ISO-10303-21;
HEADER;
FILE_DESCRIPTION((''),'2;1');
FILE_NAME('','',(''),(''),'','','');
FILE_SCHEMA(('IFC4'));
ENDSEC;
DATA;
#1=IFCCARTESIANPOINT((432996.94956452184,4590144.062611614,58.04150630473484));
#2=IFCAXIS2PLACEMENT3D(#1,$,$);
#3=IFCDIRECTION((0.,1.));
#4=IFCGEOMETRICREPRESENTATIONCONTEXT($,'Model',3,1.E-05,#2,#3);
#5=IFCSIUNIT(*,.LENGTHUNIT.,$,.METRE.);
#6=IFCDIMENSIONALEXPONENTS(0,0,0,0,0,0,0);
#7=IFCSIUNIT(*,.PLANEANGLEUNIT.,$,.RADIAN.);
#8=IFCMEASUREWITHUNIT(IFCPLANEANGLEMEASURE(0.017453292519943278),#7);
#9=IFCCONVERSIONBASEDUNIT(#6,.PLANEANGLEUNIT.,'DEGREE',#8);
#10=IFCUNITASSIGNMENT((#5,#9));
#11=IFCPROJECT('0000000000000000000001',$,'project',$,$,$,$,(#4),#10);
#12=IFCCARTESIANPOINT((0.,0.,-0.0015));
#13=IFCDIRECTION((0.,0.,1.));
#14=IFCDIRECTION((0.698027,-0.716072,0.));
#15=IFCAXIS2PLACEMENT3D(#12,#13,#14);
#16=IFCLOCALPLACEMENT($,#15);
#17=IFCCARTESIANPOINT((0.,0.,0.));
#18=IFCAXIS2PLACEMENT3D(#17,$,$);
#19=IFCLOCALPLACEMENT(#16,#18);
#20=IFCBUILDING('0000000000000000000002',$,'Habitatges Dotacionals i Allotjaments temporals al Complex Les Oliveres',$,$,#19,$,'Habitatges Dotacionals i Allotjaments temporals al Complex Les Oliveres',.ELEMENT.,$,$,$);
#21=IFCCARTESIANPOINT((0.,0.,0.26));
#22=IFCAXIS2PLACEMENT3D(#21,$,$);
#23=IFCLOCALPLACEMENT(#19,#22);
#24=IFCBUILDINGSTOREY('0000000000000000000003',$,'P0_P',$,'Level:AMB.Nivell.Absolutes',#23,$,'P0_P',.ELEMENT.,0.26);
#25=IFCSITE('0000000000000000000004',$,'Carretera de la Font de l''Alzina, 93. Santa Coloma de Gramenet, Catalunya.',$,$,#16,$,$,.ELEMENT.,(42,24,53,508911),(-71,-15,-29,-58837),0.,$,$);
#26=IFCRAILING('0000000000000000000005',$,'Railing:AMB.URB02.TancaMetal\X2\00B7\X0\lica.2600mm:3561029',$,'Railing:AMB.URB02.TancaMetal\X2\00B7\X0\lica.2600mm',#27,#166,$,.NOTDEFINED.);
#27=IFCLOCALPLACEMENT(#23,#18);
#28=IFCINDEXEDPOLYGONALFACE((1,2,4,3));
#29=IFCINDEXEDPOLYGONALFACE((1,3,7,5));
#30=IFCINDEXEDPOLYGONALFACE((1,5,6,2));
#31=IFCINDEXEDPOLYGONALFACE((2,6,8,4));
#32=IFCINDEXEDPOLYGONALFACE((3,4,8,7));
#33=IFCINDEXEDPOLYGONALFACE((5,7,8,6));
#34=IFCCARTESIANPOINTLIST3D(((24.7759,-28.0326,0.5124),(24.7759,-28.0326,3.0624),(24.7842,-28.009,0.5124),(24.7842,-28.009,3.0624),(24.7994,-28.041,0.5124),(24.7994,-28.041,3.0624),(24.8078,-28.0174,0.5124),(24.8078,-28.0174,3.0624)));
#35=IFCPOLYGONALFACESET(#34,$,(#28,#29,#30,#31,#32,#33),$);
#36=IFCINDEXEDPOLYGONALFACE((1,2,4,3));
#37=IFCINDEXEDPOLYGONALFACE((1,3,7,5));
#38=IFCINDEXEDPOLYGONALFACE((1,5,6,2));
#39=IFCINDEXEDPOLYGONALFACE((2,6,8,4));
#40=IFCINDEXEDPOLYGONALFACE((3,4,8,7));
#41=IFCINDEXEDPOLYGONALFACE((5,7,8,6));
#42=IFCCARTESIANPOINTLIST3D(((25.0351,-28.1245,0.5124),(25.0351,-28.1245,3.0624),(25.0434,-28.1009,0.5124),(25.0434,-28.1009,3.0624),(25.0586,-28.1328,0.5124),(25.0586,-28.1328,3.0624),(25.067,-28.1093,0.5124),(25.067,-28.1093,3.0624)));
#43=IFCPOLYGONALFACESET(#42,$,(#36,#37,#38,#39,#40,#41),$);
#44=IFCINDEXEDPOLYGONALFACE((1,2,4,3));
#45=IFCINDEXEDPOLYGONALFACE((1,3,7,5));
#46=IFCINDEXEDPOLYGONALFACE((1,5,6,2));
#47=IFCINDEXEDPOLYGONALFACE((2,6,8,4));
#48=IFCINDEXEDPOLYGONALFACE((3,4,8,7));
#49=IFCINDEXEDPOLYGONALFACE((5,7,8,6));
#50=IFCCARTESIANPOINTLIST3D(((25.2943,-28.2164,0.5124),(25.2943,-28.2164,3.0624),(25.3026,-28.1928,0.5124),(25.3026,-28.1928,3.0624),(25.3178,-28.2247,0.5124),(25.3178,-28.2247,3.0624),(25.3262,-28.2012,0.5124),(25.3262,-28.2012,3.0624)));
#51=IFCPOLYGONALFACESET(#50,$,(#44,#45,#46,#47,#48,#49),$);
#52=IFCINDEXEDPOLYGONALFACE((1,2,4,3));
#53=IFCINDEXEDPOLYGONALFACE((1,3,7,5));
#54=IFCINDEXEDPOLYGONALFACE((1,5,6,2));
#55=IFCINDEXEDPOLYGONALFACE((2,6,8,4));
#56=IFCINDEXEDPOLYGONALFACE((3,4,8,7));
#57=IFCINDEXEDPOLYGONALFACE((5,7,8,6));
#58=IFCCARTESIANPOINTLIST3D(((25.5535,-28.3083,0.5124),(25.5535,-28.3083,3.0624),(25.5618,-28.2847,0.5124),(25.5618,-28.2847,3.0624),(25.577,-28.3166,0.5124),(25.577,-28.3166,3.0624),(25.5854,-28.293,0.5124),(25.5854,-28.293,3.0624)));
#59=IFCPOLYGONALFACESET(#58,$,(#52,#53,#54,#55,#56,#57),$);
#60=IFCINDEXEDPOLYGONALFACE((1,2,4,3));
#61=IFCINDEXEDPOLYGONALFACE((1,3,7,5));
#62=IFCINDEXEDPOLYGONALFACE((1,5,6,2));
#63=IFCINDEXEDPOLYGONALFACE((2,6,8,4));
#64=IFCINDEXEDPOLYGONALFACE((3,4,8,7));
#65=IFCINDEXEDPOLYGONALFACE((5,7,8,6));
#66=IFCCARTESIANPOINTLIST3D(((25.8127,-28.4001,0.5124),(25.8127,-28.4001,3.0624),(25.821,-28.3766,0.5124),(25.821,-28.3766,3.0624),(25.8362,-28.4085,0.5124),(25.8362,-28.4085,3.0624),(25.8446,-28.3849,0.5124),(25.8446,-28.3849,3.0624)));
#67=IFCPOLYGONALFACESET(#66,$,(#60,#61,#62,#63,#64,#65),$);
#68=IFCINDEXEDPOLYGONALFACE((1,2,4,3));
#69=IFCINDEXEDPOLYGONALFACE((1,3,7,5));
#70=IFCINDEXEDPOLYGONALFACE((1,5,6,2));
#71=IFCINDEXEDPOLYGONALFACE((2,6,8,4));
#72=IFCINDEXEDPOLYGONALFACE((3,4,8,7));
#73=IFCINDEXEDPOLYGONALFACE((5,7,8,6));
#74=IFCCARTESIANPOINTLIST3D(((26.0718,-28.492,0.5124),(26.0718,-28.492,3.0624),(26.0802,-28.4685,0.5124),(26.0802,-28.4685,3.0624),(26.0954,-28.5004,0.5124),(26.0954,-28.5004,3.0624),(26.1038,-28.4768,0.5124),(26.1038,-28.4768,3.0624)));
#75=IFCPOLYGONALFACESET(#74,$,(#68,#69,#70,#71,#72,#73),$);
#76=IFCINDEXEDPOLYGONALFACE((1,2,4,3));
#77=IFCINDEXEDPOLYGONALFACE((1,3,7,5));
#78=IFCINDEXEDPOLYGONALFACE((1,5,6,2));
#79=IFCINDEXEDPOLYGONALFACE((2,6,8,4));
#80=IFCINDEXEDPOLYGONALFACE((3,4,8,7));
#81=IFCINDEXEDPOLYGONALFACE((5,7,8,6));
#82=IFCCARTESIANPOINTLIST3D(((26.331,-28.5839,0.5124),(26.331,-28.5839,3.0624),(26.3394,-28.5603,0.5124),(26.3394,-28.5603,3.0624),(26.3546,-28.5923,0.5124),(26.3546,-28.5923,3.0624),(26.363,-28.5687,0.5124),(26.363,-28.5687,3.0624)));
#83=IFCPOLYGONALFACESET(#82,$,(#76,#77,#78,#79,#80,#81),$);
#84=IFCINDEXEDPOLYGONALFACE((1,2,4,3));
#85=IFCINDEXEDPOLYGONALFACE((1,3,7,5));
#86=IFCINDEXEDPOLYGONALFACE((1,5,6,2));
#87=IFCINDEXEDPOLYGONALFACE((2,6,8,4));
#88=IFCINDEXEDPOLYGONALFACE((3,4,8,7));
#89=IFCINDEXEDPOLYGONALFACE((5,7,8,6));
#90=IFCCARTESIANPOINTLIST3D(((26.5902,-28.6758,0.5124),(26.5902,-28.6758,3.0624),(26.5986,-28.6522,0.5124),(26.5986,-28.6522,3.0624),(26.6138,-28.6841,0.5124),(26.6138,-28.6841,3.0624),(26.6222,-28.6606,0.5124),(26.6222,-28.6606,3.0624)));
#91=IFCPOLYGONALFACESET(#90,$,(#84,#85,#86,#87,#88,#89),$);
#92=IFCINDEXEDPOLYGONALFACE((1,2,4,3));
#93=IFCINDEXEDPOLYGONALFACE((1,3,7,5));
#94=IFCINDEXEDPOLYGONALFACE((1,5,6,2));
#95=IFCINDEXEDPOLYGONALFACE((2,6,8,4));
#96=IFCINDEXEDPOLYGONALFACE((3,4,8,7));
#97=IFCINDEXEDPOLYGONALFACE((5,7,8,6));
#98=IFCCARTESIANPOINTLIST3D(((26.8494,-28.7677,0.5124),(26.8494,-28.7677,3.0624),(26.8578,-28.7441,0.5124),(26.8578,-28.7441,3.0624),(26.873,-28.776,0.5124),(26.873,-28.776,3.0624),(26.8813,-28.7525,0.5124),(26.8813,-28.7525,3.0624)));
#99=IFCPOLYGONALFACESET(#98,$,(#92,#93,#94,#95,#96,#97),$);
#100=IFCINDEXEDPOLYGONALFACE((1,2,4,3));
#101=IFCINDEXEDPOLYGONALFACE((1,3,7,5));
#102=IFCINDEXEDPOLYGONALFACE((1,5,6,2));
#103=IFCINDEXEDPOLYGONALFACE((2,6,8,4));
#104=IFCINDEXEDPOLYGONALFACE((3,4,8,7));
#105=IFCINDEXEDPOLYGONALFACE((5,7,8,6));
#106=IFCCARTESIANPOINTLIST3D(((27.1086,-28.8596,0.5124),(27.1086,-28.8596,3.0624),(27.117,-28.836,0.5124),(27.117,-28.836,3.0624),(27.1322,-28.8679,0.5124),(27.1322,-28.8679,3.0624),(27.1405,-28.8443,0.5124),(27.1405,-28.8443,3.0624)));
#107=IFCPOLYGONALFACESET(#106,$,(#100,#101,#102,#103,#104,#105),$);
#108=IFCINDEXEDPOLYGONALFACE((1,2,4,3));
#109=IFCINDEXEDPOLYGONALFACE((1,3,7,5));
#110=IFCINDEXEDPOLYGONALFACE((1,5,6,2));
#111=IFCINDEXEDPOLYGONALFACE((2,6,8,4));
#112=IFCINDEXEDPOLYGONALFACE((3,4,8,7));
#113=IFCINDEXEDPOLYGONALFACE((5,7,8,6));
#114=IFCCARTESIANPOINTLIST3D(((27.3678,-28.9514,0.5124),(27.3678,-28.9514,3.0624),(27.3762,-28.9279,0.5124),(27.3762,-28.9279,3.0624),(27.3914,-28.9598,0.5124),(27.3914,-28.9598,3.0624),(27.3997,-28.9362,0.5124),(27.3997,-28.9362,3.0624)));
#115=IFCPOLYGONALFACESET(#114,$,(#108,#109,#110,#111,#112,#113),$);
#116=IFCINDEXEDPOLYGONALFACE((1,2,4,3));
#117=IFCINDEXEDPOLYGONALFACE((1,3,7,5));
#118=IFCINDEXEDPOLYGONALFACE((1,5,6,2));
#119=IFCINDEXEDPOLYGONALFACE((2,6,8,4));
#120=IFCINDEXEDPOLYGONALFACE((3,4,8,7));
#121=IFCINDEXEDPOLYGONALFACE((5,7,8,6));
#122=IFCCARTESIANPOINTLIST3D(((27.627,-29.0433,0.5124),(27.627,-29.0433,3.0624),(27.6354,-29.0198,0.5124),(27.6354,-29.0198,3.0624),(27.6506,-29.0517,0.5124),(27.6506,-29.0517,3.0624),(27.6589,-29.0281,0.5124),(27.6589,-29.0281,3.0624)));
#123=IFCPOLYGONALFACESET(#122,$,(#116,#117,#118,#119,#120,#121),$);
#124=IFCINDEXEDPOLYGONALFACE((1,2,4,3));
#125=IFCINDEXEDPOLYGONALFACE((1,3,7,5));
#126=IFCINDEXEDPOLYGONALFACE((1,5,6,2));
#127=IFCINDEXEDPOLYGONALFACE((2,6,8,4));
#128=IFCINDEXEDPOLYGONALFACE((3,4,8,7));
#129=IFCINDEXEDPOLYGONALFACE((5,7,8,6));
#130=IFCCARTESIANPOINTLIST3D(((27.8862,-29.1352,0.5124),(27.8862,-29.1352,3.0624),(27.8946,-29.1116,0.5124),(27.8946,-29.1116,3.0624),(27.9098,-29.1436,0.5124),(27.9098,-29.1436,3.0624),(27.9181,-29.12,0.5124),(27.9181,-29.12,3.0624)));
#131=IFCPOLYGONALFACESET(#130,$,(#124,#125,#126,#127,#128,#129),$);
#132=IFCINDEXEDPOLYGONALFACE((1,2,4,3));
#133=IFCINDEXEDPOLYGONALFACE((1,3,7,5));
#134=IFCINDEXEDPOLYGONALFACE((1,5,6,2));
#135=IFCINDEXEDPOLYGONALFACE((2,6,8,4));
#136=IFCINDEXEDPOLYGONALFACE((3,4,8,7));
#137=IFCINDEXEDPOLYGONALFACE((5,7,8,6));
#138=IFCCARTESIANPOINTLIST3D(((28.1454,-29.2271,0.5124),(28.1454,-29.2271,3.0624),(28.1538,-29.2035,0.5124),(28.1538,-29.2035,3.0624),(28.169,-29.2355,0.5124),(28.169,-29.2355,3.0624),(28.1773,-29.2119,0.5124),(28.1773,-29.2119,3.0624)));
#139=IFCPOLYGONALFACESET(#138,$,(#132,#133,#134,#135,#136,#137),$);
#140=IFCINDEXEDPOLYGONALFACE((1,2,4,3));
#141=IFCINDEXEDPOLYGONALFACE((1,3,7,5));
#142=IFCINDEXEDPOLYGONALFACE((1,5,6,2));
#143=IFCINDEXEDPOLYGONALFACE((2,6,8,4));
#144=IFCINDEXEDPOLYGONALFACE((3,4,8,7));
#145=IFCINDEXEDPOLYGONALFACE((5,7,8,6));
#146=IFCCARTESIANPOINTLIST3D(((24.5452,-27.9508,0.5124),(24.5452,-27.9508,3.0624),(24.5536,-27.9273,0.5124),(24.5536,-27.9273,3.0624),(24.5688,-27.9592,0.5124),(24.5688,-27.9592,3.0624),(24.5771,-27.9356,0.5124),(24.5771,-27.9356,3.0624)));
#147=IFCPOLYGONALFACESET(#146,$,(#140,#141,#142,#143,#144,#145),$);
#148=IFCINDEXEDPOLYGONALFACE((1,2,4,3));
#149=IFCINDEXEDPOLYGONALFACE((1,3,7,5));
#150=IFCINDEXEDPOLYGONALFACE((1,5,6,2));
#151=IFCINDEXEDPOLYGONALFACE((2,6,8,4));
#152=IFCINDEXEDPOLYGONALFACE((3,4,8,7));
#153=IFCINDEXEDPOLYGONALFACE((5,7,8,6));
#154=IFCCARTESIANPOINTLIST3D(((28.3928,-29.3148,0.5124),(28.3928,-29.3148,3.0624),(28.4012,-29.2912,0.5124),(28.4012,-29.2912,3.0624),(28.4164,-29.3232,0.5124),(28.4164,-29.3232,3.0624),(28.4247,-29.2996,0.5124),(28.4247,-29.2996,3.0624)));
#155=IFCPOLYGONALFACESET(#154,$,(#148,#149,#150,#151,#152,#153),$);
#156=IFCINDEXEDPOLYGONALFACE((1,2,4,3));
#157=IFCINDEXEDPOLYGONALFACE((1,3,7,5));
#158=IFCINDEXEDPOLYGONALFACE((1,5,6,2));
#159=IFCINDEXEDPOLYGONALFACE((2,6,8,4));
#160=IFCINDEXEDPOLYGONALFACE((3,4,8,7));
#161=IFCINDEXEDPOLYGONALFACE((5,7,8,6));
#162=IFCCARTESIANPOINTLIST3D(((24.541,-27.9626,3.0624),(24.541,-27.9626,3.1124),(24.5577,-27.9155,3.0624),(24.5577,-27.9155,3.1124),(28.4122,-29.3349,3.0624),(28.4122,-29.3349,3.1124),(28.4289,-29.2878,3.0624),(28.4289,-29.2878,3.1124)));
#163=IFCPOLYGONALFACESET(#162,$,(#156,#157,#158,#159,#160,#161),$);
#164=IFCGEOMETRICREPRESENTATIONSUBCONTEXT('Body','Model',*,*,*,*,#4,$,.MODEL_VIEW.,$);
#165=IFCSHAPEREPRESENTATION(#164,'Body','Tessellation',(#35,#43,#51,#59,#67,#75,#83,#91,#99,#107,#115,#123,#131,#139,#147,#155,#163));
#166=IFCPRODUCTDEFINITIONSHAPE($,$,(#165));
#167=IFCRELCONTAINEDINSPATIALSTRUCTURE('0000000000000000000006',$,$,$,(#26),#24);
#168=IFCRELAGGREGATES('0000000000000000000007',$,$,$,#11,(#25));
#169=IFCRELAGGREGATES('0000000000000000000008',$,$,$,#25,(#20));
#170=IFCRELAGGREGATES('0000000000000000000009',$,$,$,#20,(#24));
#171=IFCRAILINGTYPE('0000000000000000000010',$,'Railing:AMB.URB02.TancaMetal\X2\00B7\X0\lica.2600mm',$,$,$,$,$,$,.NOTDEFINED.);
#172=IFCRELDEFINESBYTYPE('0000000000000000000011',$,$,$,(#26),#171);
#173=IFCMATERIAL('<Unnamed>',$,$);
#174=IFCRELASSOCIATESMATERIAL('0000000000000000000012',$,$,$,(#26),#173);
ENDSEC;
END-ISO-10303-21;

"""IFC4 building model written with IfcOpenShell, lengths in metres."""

from ifc_helpers import new_model, entity, si_unit, converted_unit, direction, frame, origin, place, context, subcontext, project, spatial, indexed_curve, outline, extrude, material, type_object, element, save


model = new_model("IFC4")

# Units and contexts
model_context = context("Model", 3, precision=1e-05, world=frame((432996.94956452184, 4590144.062611614, 58.04150630473484)), true_north=direction((0.0, 1.0)))
body_context = subcontext(model_context, "Body", "Model", "MODEL_VIEW")
ifc_project = project(units=[si_unit("LENGTHUNIT", "METRE"), converted_unit("PLANEANGLEUNIT", "DEGREE", entity("IfcPlaneAngleMeasure", 0.017453292519943278), si_unit("PLANEANGLEUNIT", "RADIAN"), dimensions=[0, 0, 0, 0, 0, 0, 0])], contexts=[model_context])

# Site, building, storey
site_placement = place(None, frame((0.0, 0.0, -0.0015), z_axis=(0.0, 0.0, 1.0), x_axis=(0.698027, -0.716072, 0.0)))
site = spatial("IfcSite", under=ifc_project, at=site_placement, Name="Carretera de la Font de l'Alzina, 93. Santa Coloma de Gramenet, Catalunya.", CompositionType="ELEMENT", RefLatitude=(42, 24, 53, 508911), RefLongitude=(-71, -15, -29, -58837), RefElevation=0.0)
building_placement = place(site_placement, origin())
building = spatial("IfcBuilding", under=site, at=building_placement, Name="Habitatges Dotacionals i Allotjaments temporals al Complex Les Oliveres", LongName="Habitatges Dotacionals i Allotjaments temporals al Complex Les Oliveres", CompositionType="ELEMENT")
storey_placement = place(building_placement, frame((0.0, 0.0, 0.26)))
storey = spatial("IfcBuildingStorey", under=building, at=storey_placement, Name="P0_P", ObjectType="Level:AMB.Nivell.Absolutes", LongName="P0_P", CompositionType="ELEMENT", Elevation=0.26)

# Shared definitions
ifc_material_1 = material(Name="<Unnamed>")

# Railing
railing_type = type_object("IfcRailingType", Name="Railing:AMB.URB02.TancaMetal·lica.2600mm", PredefinedType="NOTDEFINED")
railing_placement = place(storey_placement, origin())
element("IfcRailing", 1, at=railing_placement, inside=storey, type_object=railing_type, material=ifc_material_1, Name="Railing:AMB.URB02.TancaMetal·lica.2600mm:3561029", ObjectType="Railing:AMB.URB02.TancaMetal·lica.2600mm", PredefinedType="NOTDEFINED", context=body_context, shape_type="SweptSolid", body=[
    extrude(outline(indexed_curve([(-0.0125, -0.0125), (0.0125, -0.0125), (0.0125, 0.0125), (-0.0125, 0.0125), (-0.0125, -0.0125)], self_intersect=False)), frame((24.7918, -28.025, 0.5124), z_axis=(0.0, 0.0, 1.0), x_axis=(-0.942529, 0.334126, 0.0)), (0.0, 0.0, 1.0), 2.55),
    extrude(outline(indexed_curve([(-0.0125, -0.0125), (0.0125, -0.0125), (0.0125, 0.0125), (-0.0125, 0.0125), (-0.0125, -0.0125)], self_intersect=False)), frame((25.051, -28.1169, 0.5124), z_axis=(0.0, 0.0, 1.0), x_axis=(-0.942529, 0.334126, 0.0)), (0.0, 0.0, 1.0), 2.55),
    extrude(outline(indexed_curve([(-0.0125, -0.0125), (0.0125, -0.0125), (0.0125, 0.0125), (-0.0125, 0.0125), (-0.0125, -0.0125)], self_intersect=False)), frame((25.3102, -28.2088, 0.5124), z_axis=(0.0, 0.0, 1.0), x_axis=(-0.942529, 0.334126, 0.0)), (0.0, 0.0, 1.0), 2.55),
    extrude(outline(indexed_curve([(-0.0125, -0.0125), (0.0125, -0.0125), (0.0125, 0.0125), (-0.0125, 0.0125), (-0.0125, -0.0125)], self_intersect=False)), frame((25.5694, -28.3006, 0.5124), z_axis=(0.0, 0.0, 1.0), x_axis=(-0.942529, 0.334126, 0.0)), (0.0, 0.0, 1.0), 2.55),
    extrude(outline(indexed_curve([(-0.0125, -0.0125), (0.0125, -0.0125), (0.0125, 0.0125), (-0.0125, 0.0125), (-0.0125, -0.0125)], self_intersect=False)), frame((25.8286, -28.3925, 0.5124), z_axis=(0.0, 0.0, 1.0), x_axis=(-0.942529, 0.334126, 0.0)), (0.0, 0.0, 1.0), 2.55),
    extrude(outline(indexed_curve([(-0.0125, -0.0125), (0.0125, -0.0125), (0.0125, 0.0125), (-0.0125, 0.0125), (-0.0125, -0.0125)], self_intersect=False)), frame((26.0878, -28.4844, 0.5124), z_axis=(0.0, 0.0, 1.0), x_axis=(-0.942529, 0.334126, 0.0)), (0.0, 0.0, 1.0), 2.55),
    extrude(outline(indexed_curve([(-0.0125, -0.0125), (0.0125, -0.0125), (0.0125, 0.0125), (-0.0125, 0.0125), (-0.0125, -0.0125)], self_intersect=False)), frame((26.347, -28.5763, 0.5124), z_axis=(0.0, 0.0, 1.0), x_axis=(-0.942529, 0.334126, 0.0)), (0.0, 0.0, 1.0), 2.55),
    extrude(outline(indexed_curve([(-0.0125, -0.0125), (0.0125, -0.0125), (0.0125, 0.0125), (-0.0125, 0.0125), (-0.0125, -0.0125)], self_intersect=False)), frame((26.6062, -28.6682, 0.5124), z_axis=(0.0, 0.0, 1.0), x_axis=(-0.942529, 0.334126, 0.0)), (0.0, 0.0, 1.0), 2.55),
    extrude(outline(indexed_curve([(-0.0125, -0.0125), (0.0125, -0.0125), (0.0125, 0.0125), (-0.0125, 0.0125), (-0.0125, -0.0125)], self_intersect=False)), frame((26.8654, -28.7601, 0.5124), z_axis=(0.0, 0.0, 1.0), x_axis=(-0.942529, 0.334126, 0.0)), (0.0, 0.0, 1.0), 2.55),
    extrude(outline(indexed_curve([(-0.0125, -0.0125), (0.0125, -0.0125), (0.0125, 0.0125), (-0.0125, 0.0125), (-0.0125, -0.0125)], self_intersect=False)), frame((27.1246, -28.852, 0.5124), z_axis=(0.0, 0.0, 1.0), x_axis=(-0.942529, 0.334126, 0.0)), (0.0, 0.0, 1.0), 2.55),
    extrude(outline(indexed_curve([(-0.0125, -0.0125), (0.0125, -0.0125), (0.0125, 0.0125), (-0.0125, 0.0125), (-0.0125, -0.0125)], self_intersect=False)), frame((27.3838, -28.9438, 0.5124), z_axis=(0.0, 0.0, 1.0), x_axis=(-0.942529, 0.334126, 0.0)), (0.0, 0.0, 1.0), 2.55),
    extrude(outline(indexed_curve([(-0.0125, -0.0125), (0.0125, -0.0125), (0.0125, 0.0125), (-0.0125, 0.0125), (-0.0125, -0.0125)], self_intersect=False)), frame((27.643, -29.0357, 0.5124), z_axis=(0.0, 0.0, 1.0), x_axis=(-0.942529, 0.334126, 0.0)), (0.0, 0.0, 1.0), 2.55),
    extrude(outline(indexed_curve([(-0.0125, -0.0125), (0.0125, -0.0125), (0.0125, 0.0125), (-0.0125, 0.0125), (-0.0125, -0.0125)], self_intersect=False)), frame((27.9022, -29.1276, 0.5124), z_axis=(0.0, 0.0, 1.0), x_axis=(-0.942529, 0.334126, 0.0)), (0.0, 0.0, 1.0), 2.55),
    extrude(outline(indexed_curve([(-0.0125, -0.0125), (0.0125, -0.0125), (0.0125, 0.0125), (-0.0125, 0.0125), (-0.0125, -0.0125)], self_intersect=False)), frame((28.1614, -29.2195, 0.5124), z_axis=(0.0, 0.0, 1.0), x_axis=(-0.942529, 0.334126, 0.0)), (0.0, 0.0, 1.0), 2.55),
    extrude(outline(indexed_curve([(-0.0125, -0.0125), (0.0125, -0.0125), (0.0125, 0.0125), (-0.0125, 0.0125), (-0.0125, -0.0125)], self_intersect=False)), frame((24.5612, -27.9432, 0.5124), z_axis=(0.0, 0.0, 1.0), x_axis=(-0.942529, 0.334126, 0.0)), (0.0, 0.0, 1.0), 2.55),
    extrude(outline(indexed_curve([(-0.0125, -0.0125), (0.0125, -0.0125), (0.0125, 0.0125), (-0.0125, 0.0125), (-0.0125, -0.0125)], self_intersect=False)), frame((28.4088, -29.3072, 0.5124), z_axis=(0.0, 0.0, 1.0), x_axis=(-0.942529, 0.334126, 0.0)), (0.0, 0.0, 1.0), 2.55),
    extrude(outline(indexed_curve([(-2.0536, -0.025), (2.0536, -0.025), (2.0536, 0.025), (-2.0536, 0.025), (-2.0536, -0.025)], self_intersect=False)), frame((26.485, -28.6252, 3.0624), z_axis=(0.0, 0.0, 1.0), x_axis=(-0.942529, 0.334126, 0.0)), (0.0, 0.0, 1.0), 0.05),
])

save(model, "model.ifc")
